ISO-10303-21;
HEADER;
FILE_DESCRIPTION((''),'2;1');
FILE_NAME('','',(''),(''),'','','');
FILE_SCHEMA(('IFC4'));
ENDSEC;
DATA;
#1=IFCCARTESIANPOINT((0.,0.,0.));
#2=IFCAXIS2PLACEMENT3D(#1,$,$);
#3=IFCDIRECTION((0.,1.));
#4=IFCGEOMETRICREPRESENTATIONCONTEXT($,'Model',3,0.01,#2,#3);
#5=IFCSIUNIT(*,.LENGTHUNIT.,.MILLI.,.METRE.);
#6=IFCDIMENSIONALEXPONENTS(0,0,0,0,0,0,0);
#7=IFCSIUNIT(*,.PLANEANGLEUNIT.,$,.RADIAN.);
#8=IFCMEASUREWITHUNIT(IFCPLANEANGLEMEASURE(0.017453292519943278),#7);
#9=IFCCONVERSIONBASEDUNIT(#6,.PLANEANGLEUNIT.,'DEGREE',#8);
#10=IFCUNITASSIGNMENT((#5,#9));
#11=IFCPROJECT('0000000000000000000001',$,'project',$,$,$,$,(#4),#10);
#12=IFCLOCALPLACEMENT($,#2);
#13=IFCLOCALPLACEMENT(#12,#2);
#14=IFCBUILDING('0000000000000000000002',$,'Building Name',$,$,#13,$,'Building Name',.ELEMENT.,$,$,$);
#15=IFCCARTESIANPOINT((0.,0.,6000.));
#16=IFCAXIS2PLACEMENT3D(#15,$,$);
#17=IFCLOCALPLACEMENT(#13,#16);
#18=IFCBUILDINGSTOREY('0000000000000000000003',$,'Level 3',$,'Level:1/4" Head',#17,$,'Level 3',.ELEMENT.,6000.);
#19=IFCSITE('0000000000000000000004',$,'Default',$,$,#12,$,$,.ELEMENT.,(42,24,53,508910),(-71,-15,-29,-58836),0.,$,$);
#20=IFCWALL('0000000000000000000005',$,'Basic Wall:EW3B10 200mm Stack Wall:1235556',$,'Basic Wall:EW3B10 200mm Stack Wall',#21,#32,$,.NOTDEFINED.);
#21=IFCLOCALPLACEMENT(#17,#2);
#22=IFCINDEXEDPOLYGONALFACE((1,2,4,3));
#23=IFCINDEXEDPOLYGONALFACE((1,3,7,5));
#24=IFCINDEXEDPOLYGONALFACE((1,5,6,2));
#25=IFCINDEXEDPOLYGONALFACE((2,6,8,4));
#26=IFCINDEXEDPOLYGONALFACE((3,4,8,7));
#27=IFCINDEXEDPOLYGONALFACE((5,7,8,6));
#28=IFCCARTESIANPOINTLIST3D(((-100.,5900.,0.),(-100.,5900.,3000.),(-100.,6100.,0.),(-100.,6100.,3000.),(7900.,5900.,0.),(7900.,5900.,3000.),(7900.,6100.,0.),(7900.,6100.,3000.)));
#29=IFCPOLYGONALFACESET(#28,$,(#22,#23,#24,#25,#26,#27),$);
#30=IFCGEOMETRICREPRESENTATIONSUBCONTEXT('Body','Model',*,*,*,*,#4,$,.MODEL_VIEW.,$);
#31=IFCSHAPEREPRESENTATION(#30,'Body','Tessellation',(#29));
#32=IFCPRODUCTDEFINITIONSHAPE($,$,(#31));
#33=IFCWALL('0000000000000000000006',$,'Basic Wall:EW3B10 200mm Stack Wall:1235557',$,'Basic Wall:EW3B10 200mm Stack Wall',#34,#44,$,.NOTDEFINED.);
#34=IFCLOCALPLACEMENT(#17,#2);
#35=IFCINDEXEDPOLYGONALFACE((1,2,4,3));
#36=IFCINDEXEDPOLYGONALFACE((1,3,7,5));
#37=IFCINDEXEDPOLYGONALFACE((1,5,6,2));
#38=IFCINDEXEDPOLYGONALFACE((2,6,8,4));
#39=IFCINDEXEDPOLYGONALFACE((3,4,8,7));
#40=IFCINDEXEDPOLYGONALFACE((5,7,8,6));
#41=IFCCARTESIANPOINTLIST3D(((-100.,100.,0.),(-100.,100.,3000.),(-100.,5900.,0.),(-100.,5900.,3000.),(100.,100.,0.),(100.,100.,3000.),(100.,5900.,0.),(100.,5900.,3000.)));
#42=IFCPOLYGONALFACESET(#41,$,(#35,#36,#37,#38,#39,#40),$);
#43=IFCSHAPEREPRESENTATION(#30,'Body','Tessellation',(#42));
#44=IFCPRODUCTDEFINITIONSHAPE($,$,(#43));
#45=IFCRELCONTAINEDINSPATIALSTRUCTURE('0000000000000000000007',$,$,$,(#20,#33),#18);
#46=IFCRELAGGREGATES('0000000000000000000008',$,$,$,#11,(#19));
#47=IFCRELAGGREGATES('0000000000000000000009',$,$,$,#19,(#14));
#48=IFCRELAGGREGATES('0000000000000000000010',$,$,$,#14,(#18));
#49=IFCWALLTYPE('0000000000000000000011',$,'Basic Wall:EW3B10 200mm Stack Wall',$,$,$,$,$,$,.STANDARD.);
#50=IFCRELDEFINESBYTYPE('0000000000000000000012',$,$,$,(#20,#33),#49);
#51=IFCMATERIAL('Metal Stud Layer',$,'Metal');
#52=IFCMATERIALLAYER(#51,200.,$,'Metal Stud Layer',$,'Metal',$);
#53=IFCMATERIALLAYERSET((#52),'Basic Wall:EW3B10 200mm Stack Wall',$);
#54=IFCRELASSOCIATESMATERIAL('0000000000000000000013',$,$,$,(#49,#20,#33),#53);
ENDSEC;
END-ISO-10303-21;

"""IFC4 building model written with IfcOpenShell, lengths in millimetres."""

from ifc_helpers import new_model, entity, si_unit, converted_unit, direction, frame, frame_2d, origin, place, context, subcontext, project, spatial, rectangle, extrude, material, layer, layer_set, layer_usage, type_object, element, save


model = new_model("IFC4")

# Units and contexts
model_context = context("Model", 3, precision=0.01, world=origin(), true_north=direction((0.0, 1.0)))
body_context = subcontext(model_context, "Body", "Model", "MODEL_VIEW")
ifc_project = project(units=[si_unit("LENGTHUNIT", "METRE", prefix="MILLI"), converted_unit("PLANEANGLEUNIT", "DEGREE", entity("IfcPlaneAngleMeasure", 0.017453292519943278), si_unit("PLANEANGLEUNIT", "RADIAN"), dimensions=[0, 0, 0, 0, 0, 0, 0])], contexts=[model_context])

# Site, building, storey
site_placement = place(None, origin())
site = spatial("IfcSite", under=ifc_project, at=site_placement, Name="Default", CompositionType="ELEMENT", RefLatitude=(42, 24, 53, 508910), RefLongitude=(-71, -15, -29, -58836), RefElevation=0.0)
building_placement = place(site_placement, origin())
building = spatial("IfcBuilding", under=site, at=building_placement, Name="Building Name", LongName="Building Name", CompositionType="ELEMENT")
storey_placement = place(building_placement, frame((0.0, 0.0, 6000.0)))
storey = spatial("IfcBuildingStorey", under=building, at=storey_placement, Name="Level 3", ObjectType="Level:1/4\" Head", LongName="Level 3", CompositionType="ELEMENT", Elevation=6000.0)

# Shared definitions
ifc_material_1 = material(Name="Metal Stud Layer", Category="Metal")
ifc_layer_1 = layer(ifc_material_1, 200.0, Name="Metal Stud Layer", Category="Metal")
ifc_layer_set_1 = layer_set([ifc_layer_1], Name="Basic Wall:EW3B10 200mm Stack Wall")
wall_type = type_object("IfcWallType", Name="Basic Wall:EW3B10 200mm Stack Wall", PredefinedType="STANDARD", material=ifc_layer_set_1)

# Walls
ifc_layer_usage_1 = layer_usage(ifc_layer_set_1, "AXIS2", "NEGATIVE", 100.0)
wall_1_placement = place(storey_placement, frame((7900.0, 6000.0, 0.0), z_axis=(0.0, 0.0, 1.0), x_axis=(-1.0, 0.0, 0.0)))
element("IfcWall", 1, at=wall_1_placement, inside=storey, type_object=wall_type, material=ifc_layer_usage_1, Name="Basic Wall:EW3B10 200mm Stack Wall:1235556", ObjectType="Basic Wall:EW3B10 200mm Stack Wall", PredefinedType="NOTDEFINED", context=body_context, shape_type="SweptSolid", body=[
    extrude(rectangle(XDim=8000.0, YDim=200.0, at=frame_2d((4000.0, 0.0), x_axis=(-1.0, 0.0))), origin(), (0.0, 0.0, 1.0), 3000.0),
])
ifc_layer_usage_2 = layer_usage(ifc_layer_set_1, "AXIS2", "NEGATIVE", 100.0)
wall_2_placement = place(storey_placement, frame((0.0, 5900.0, 0.0), z_axis=(0.0, 0.0, 1.0), x_axis=(0.0, -1.0, 0.0)))
element("IfcWall", 2, at=wall_2_placement, inside=storey, type_object=wall_type, material=ifc_layer_usage_2, Name="Basic Wall:EW3B10 200mm Stack Wall:1235557", ObjectType="Basic Wall:EW3B10 200mm Stack Wall", PredefinedType="NOTDEFINED", context=body_context, shape_type="SweptSolid", body=[
    extrude(rectangle(XDim=5800.0, YDim=200.0, at=frame_2d((2900.0, 0.0), x_axis=(-1.0, 0.0))), origin(), (0.0, 0.0, 1.0), 3000.0),
])

save(model, "model.ifc")
